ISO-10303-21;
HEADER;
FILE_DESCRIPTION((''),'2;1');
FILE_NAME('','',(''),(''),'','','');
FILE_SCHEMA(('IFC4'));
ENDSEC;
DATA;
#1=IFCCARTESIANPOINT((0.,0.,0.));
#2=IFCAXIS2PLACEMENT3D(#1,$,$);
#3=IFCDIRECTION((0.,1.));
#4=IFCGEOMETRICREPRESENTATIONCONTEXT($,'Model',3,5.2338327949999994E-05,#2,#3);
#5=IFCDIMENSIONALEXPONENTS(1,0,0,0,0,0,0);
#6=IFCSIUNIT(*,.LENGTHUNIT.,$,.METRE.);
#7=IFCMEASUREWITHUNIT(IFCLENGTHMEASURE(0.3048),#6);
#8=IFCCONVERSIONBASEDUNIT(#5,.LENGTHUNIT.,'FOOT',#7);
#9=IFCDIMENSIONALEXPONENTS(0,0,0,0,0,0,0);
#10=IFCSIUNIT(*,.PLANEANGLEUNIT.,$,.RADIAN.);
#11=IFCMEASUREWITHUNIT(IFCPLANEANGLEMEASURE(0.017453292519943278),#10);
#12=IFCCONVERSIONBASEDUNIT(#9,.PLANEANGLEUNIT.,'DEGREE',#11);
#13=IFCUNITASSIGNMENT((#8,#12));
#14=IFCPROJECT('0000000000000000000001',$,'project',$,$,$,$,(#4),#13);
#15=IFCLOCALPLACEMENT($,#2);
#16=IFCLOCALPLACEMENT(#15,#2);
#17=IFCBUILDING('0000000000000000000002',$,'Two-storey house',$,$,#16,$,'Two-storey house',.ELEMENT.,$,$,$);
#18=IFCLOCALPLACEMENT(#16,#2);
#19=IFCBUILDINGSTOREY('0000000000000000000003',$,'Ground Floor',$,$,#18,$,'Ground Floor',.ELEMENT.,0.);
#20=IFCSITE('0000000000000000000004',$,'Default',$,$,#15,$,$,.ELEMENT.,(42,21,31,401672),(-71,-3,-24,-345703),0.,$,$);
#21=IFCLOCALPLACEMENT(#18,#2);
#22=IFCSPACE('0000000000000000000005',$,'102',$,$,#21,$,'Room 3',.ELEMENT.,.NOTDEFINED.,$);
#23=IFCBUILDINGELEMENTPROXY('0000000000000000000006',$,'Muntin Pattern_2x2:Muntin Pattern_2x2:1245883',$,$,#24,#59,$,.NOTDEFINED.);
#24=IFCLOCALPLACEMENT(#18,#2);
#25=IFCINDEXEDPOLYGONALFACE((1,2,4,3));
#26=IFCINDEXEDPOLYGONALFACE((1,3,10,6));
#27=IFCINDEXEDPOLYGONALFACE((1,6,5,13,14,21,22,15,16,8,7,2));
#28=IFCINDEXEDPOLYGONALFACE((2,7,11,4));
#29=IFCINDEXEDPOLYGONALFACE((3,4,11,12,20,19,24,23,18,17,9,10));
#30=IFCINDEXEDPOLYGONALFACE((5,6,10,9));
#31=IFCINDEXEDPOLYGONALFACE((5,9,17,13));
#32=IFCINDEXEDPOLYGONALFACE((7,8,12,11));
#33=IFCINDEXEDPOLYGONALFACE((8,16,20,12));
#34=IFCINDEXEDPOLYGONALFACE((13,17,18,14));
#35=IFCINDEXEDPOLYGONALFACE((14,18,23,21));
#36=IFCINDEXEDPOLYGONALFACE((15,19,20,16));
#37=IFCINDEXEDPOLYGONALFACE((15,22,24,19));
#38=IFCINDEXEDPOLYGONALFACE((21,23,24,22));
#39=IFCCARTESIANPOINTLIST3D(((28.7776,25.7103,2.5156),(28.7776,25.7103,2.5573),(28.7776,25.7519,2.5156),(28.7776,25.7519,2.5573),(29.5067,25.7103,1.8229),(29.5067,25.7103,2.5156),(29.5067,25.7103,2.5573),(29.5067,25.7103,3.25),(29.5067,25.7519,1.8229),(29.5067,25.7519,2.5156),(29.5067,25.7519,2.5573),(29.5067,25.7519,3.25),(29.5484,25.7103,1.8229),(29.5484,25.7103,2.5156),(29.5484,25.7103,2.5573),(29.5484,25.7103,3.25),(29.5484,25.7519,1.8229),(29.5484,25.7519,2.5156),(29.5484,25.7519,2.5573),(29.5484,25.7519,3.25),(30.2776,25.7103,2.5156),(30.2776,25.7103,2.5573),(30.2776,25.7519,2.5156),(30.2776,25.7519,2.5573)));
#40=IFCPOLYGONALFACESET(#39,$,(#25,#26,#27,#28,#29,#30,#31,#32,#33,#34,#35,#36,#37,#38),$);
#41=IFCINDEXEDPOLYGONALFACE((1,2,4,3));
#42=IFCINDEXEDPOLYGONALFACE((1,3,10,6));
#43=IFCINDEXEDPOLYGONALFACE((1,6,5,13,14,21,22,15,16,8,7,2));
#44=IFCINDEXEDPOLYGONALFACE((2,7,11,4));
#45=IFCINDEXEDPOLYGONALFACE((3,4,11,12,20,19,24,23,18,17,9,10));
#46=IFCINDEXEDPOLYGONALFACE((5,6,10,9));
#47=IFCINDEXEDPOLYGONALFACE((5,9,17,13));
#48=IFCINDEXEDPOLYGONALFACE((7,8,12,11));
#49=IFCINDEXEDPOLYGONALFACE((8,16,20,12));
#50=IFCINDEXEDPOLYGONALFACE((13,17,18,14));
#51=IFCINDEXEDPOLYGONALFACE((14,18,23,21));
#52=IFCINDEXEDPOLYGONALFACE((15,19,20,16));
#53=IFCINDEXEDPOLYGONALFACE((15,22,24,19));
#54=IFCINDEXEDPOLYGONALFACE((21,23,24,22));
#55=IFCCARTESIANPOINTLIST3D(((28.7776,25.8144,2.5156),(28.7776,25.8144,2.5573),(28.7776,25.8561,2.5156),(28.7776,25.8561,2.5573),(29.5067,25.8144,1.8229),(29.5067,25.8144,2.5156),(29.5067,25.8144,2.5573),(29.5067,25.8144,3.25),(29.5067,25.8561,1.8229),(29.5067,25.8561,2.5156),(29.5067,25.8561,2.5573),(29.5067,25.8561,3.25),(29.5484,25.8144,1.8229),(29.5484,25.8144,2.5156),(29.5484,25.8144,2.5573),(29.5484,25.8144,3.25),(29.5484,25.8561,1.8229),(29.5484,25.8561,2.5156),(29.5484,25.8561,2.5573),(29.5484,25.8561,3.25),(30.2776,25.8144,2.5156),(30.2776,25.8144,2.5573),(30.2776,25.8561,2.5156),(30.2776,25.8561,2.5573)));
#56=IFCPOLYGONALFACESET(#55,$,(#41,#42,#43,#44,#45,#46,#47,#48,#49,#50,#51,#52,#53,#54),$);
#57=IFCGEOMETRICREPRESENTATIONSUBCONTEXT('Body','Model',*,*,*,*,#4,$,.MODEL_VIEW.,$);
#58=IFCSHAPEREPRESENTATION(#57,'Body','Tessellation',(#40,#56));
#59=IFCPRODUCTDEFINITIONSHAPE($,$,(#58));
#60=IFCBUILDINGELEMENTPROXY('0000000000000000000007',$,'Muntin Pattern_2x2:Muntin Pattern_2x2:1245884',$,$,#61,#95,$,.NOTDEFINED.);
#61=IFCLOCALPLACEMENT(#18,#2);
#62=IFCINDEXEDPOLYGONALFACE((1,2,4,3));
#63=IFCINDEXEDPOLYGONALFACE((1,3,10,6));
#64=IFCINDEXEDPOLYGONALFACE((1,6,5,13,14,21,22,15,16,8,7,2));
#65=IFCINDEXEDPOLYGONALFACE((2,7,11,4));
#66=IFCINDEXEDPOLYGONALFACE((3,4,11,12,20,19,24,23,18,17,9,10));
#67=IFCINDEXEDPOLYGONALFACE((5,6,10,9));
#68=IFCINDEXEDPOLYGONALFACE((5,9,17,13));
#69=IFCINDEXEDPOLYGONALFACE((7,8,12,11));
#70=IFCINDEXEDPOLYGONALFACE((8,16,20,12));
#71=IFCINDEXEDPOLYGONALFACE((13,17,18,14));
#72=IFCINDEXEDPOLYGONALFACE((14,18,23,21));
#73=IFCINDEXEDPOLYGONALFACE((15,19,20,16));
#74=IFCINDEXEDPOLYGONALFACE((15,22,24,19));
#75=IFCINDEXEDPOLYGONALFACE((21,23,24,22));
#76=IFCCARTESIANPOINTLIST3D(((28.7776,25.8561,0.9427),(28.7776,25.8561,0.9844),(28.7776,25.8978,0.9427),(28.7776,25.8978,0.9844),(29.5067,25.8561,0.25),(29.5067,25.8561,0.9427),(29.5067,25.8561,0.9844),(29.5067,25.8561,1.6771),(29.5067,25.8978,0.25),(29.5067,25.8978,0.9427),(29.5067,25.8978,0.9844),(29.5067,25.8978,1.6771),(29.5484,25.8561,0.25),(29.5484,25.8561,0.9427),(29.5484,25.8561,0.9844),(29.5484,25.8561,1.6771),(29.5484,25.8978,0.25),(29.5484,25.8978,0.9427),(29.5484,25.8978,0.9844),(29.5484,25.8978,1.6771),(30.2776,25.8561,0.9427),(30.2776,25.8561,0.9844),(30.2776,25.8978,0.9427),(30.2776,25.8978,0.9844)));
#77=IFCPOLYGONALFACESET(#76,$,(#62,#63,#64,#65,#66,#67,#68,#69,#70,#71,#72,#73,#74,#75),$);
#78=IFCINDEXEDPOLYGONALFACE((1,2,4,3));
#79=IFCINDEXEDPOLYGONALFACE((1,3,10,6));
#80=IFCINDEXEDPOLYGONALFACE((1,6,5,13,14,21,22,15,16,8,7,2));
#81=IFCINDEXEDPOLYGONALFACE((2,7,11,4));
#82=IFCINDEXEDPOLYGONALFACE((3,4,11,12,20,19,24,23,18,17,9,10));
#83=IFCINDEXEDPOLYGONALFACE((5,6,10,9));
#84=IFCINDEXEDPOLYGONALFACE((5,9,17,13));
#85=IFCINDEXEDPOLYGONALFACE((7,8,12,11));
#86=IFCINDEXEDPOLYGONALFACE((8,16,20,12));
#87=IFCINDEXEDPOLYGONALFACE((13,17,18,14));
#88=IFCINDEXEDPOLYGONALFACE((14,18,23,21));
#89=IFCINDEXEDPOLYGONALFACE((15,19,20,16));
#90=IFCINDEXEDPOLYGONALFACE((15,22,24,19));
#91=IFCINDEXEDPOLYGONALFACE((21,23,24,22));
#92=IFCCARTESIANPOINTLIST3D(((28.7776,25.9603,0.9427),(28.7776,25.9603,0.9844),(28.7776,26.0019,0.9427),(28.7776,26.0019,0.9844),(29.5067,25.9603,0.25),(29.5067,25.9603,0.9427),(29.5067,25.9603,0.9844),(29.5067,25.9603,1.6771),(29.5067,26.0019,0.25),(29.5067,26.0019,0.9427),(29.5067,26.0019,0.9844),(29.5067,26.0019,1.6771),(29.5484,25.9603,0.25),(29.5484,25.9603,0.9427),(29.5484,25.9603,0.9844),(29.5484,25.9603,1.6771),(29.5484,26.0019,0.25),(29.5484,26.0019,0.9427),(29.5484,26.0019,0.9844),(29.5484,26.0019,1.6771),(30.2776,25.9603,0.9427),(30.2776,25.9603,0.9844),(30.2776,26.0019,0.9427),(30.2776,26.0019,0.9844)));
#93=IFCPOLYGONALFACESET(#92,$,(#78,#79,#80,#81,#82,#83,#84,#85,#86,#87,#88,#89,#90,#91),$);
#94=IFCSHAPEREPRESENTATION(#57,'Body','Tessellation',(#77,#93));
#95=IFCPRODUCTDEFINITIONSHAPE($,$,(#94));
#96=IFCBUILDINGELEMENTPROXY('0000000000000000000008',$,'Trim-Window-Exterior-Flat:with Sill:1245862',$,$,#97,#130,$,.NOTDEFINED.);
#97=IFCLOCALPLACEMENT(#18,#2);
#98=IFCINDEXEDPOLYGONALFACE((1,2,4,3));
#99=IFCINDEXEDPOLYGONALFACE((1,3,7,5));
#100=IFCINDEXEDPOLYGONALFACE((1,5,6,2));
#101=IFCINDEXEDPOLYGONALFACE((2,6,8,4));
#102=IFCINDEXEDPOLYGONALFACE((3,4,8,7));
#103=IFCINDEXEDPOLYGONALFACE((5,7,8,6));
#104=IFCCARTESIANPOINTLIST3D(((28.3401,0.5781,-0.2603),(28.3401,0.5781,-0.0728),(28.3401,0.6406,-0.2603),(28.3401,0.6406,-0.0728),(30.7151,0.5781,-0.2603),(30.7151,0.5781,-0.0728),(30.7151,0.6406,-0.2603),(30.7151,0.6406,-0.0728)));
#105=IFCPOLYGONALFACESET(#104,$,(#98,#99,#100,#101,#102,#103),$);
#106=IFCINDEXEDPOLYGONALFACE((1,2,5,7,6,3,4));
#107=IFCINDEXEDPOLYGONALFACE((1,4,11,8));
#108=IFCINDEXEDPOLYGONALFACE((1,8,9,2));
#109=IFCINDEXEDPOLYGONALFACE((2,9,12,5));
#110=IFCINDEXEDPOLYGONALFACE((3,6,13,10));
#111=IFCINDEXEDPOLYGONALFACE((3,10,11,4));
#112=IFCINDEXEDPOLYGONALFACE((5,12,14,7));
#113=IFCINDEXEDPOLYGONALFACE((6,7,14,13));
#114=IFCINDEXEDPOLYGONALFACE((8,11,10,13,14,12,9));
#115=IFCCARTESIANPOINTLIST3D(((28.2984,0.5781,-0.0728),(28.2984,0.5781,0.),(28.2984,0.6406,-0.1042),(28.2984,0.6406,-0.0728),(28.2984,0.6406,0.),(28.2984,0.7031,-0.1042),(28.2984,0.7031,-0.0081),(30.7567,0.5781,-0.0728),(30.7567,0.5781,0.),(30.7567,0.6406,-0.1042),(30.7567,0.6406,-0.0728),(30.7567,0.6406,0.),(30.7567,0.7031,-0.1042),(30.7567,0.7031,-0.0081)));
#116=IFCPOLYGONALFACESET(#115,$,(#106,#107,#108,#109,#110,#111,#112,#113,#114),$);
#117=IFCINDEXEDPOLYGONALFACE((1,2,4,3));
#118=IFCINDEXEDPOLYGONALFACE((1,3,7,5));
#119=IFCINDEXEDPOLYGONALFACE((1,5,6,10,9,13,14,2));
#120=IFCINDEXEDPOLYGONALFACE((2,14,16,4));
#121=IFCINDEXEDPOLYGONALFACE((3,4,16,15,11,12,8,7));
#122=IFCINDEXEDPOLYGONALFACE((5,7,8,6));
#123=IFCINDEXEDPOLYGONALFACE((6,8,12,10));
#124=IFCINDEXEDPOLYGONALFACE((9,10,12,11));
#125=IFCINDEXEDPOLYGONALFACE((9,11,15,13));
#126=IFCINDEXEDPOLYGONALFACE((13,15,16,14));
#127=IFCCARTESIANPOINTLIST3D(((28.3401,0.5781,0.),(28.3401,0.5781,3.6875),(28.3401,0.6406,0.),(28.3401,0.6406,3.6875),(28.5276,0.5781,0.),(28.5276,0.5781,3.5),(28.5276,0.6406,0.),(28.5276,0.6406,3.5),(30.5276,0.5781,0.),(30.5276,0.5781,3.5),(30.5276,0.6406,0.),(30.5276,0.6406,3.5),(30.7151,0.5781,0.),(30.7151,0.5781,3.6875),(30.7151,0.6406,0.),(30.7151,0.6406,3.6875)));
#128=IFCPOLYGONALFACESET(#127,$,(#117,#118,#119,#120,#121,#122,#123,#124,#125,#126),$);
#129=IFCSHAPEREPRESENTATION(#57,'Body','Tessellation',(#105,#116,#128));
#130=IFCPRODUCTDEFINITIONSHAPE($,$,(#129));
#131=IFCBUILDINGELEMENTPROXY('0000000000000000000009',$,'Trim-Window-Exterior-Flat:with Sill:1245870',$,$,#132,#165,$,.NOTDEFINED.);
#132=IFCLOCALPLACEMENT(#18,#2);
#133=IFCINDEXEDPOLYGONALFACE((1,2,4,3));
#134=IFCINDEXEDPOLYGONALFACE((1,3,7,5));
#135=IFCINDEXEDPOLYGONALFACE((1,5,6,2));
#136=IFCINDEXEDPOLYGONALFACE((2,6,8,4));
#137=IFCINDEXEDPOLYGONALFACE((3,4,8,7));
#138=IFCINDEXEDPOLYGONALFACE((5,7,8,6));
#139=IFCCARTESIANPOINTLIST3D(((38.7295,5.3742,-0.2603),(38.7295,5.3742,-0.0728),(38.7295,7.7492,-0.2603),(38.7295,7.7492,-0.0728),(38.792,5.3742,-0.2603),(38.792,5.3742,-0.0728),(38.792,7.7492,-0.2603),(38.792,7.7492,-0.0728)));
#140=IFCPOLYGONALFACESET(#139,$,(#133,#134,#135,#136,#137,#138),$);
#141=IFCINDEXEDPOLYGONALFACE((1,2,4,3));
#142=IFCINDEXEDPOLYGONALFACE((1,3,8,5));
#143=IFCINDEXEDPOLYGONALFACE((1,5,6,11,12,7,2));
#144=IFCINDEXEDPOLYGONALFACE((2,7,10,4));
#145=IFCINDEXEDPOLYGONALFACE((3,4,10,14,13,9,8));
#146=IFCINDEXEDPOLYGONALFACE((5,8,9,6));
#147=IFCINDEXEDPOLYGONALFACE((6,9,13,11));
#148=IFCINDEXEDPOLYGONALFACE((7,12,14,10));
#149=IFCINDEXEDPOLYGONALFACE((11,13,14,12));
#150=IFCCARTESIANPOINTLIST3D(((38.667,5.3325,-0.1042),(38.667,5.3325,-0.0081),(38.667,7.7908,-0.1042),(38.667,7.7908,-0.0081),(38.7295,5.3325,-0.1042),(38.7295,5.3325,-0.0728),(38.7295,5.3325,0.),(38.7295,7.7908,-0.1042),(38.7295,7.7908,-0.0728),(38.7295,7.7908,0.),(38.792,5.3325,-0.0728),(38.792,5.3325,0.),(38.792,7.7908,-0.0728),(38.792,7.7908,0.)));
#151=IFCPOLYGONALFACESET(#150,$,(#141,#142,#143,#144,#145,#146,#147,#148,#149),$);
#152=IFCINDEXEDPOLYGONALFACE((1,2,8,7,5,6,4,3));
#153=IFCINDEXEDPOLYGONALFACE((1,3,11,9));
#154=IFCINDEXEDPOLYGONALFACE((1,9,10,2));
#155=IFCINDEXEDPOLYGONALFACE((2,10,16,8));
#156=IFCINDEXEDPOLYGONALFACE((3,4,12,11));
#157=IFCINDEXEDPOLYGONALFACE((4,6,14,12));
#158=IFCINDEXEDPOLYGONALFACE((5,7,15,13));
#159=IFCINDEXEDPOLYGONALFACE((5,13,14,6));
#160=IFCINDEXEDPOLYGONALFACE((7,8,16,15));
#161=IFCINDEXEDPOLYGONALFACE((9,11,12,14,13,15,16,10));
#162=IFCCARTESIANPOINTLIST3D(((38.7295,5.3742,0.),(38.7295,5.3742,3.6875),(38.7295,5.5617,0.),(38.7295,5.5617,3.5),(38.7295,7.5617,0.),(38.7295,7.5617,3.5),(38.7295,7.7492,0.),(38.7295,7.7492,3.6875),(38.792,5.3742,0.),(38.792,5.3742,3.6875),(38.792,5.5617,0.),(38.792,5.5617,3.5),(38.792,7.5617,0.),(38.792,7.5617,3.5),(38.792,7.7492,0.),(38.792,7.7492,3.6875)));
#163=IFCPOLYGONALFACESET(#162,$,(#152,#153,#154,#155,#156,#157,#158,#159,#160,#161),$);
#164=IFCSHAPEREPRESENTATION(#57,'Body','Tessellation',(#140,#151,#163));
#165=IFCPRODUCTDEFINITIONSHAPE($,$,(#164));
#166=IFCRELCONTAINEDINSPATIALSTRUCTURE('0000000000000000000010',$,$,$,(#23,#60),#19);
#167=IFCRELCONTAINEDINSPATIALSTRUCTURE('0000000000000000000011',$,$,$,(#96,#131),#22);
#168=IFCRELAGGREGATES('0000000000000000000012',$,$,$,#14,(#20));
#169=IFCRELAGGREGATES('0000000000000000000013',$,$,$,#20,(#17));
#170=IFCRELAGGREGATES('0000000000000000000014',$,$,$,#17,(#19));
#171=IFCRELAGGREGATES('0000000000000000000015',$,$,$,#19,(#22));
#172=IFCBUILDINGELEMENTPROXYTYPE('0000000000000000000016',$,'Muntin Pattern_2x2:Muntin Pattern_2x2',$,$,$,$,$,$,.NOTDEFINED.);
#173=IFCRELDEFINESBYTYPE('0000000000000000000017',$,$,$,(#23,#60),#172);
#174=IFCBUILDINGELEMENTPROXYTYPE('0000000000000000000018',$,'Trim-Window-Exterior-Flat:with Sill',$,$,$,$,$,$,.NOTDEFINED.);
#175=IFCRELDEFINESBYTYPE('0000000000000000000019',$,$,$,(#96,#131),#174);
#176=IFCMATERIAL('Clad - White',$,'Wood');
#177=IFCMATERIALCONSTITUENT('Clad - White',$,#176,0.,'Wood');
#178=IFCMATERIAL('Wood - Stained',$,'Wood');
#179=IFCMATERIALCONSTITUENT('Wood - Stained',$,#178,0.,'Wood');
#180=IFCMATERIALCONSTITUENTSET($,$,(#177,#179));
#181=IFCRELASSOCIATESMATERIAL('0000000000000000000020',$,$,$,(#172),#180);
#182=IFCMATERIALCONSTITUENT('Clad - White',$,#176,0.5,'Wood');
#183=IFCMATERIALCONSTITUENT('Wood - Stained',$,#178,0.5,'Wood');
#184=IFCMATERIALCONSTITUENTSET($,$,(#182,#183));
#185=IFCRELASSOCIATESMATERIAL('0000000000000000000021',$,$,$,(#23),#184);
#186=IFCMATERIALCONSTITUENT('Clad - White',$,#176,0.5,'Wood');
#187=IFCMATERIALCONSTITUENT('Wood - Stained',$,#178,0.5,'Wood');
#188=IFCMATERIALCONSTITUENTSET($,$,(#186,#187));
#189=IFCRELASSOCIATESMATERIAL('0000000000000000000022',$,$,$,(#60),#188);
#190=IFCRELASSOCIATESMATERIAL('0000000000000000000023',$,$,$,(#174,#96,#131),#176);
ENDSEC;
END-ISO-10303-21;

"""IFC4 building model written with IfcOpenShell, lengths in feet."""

from ifc_helpers import new_model, entity, si_unit, converted_unit, direction, frame, origin, place, context, subcontext, project, spatial, indexed_curve, outline, extrude, source, transform, mapped, material, constituent, constituent_set, type_object, type_shapes, element, save


model = new_model("IFC4")

# Units and contexts
model_context = context("Model", 3, precision=5.2338327949999994e-05, world=origin(), true_north=direction((0.0, 1.0)))
body_context = subcontext(model_context, "Body", "Model", "MODEL_VIEW")
ifc_project = project(units=[converted_unit("LENGTHUNIT", "FOOT", entity("IfcLengthMeasure", 0.3048), si_unit("LENGTHUNIT", "METRE"), dimensions=[1, 0, 0, 0, 0, 0, 0]), converted_unit("PLANEANGLEUNIT", "DEGREE", entity("IfcPlaneAngleMeasure", 0.017453292519943278), si_unit("PLANEANGLEUNIT", "RADIAN"), dimensions=[0, 0, 0, 0, 0, 0, 0])], contexts=[model_context])

# Site, building, storey
site_placement = place(None, origin())
site = spatial("IfcSite", under=ifc_project, at=site_placement, Name="Default", CompositionType="ELEMENT", RefLatitude=(42, 21, 31, 401672), RefLongitude=(-71, -3, -24, -345703), RefElevation=0.0)
building_placement = place(site_placement, origin())
building = spatial("IfcBuilding", under=site, at=building_placement, Name="Two-storey house", LongName="Two-storey house", CompositionType="ELEMENT")
storey_placement = place(building_placement, origin())
storey = spatial("IfcBuildingStorey", under=building, at=storey_placement, Name="Ground Floor", LongName="Ground Floor", CompositionType="ELEMENT", Elevation=0.0)

# Shared definitions
ifc_material_1 = material(Name="Wood - Stained", Category="Wood")

# Building element proxies
ifc_material_2 = material(Name="Clad - White", Category="Wood")
ifc_constituent_1 = constituent(ifc_material_2, Name="Clad - White", Category="Wood", fraction=0.0)
ifc_constituent_2 = constituent(ifc_material_1, Name="Wood - Stained", Category="Wood", fraction=0.0)
ifc_constituent_set_1 = constituent_set(constituents=[ifc_constituent_1, ifc_constituent_2])
building_element_proxy_type_1 = type_object("IfcBuildingElementProxyType", Name="Muntin Pattern_2x2:Muntin Pattern_2x2", PredefinedType="NOTDEFINED", material=ifc_constituent_set_1)
shared_shape_1 = source(origin(), body_context, "Body", "SweptSolid", [
    extrude(outline(indexed_curve([(0.0208, -0.0208), (0.7135, -0.0208), (0.7135, 0.0208), (0.0208, 0.0208), (0.0208, 0.75), (-0.0208, 0.75), (-0.0208, 0.0208), (-0.7135, 0.0208), (-0.7135, -0.0208), (-0.0208, -0.0208), (-0.0208, -0.75), (0.0208, -0.75), (0.0208, -0.0208)], self_intersect=False)), frame((0.0, 0.0312, 0.7135), z_axis=(0.0, 1.0, 0.0), x_axis=(0.0, 0.0, 1.0)), (0.0, 0.0, 1.0), 0.0417),
    extrude(outline(indexed_curve([(0.0208, -0.0208), (0.7135, -0.0208), (0.7135, 0.0208), (0.0208, 0.0208), (0.0208, 0.75), (-0.0208, 0.75), (-0.0208, 0.0208), (-0.7135, 0.0208), (-0.7135, -0.0208), (-0.0208, -0.0208), (-0.0208, -0.75), (0.0208, -0.75), (0.0208, -0.0208)], self_intersect=False)), frame((0.0, -0.0729, 0.7135), z_axis=(0.0, 1.0, 0.0), x_axis=(0.0, 0.0, 1.0)), (0.0, 0.0, 1.0), 0.0417),
])
type_shapes(building_element_proxy_type_1, [shared_shape_1])
ifc_constituent_3 = constituent(ifc_material_2, Name="Clad - White", Category="Wood", fraction=0.5)
ifc_constituent_4 = constituent(ifc_material_1, Name="Wood - Stained", Category="Wood", fraction=0.5)
ifc_constituent_set_2 = constituent_set(constituents=[ifc_constituent_3, ifc_constituent_4])
proxy_1_placement = place(storey_placement, frame((29.5276, 25.7832, 1.8229), z_axis=(0.0, 0.0, 1.0), x_axis=(-1.0, 0.0, 0.0)))
element("IfcBuildingElementProxy", 1, at=proxy_1_placement, inside=storey, type_object=building_element_proxy_type_1, material=ifc_constituent_set_2, Name="Muntin Pattern_2x2:Muntin Pattern_2x2:1245883", PredefinedType="NOTDEFINED", context=body_context, shape_type="MappedRepresentation", body=[
    mapped(shared_shape_1, transform((0.0, 0.0, 0.0), scale=1.0)),
])
ifc_constituent_5 = constituent(ifc_material_2, Name="Clad - White", Category="Wood", fraction=0.5)
ifc_constituent_6 = constituent(ifc_material_1, Name="Wood - Stained", Category="Wood", fraction=0.5)
ifc_constituent_set_3 = constituent_set(constituents=[ifc_constituent_5, ifc_constituent_6])
proxy_2_placement = place(storey_placement, frame((29.5276, 25.929, 0.25), z_axis=(0.0, 0.0, 1.0), x_axis=(-1.0, 0.0, 0.0)))
element("IfcBuildingElementProxy", 2, at=proxy_2_placement, inside=storey, type_object=building_element_proxy_type_1, material=ifc_constituent_set_3, Name="Muntin Pattern_2x2:Muntin Pattern_2x2:1245884", PredefinedType="NOTDEFINED", context=body_context, shape_type="MappedRepresentation", body=[
    mapped(shared_shape_1, transform((0.0, 0.0, 0.0), scale=1.0)),
])

# Shared definitions
space_1_placement = place(storey_placement, origin())
space_1 = spatial("IfcSpace", under=storey, at=space_1_placement, Name="102", LongName="Room 3", CompositionType="ELEMENT", PredefinedType="NOTDEFINED")

# Building element proxies
building_element_proxy_type_2 = type_object("IfcBuildingElementProxyType", Name="Trim-Window-Exterior-Flat:with Sill", PredefinedType="NOTDEFINED", material=ifc_material_2)
shared_shape_2 = source(origin(), body_context, "Body", "SweptSolid", [
    extrude(outline(indexed_curve([(-1.1875, -0.0938), (1.1875, -0.0938), (1.1875, 0.0938), (-1.1875, 0.0938), (-1.1875, -0.0938)], self_intersect=False)), frame((0.0, -3.6665, 0.0), z_axis=(0.0, 0.0, 1.0), x_axis=(-1.0, 0.0, 0.0)), (0.0, 0.0, 1.0), 0.0625),
    extrude(outline(indexed_curve([(-0.0625, -0.0525), (0.0, -0.0525), (0.0, -0.0211), (0.0625, -0.0211), (0.0625, 0.0517), (0.0, 0.0517), (-0.0625, 0.0436), (-0.0625, -0.0525)], self_intersect=False)), frame((-1.2292, -3.5517, 0.0625), z_axis=(1.0, 0.0, 0.0), x_axis=(0.0, 0.0, -1.0)), (0.0, 0.0, 1.0), 2.4583),
    extrude(outline(indexed_curve([(-1.8906, -1.1875), (1.7969, -1.1875), (1.7969, -1.0), (-1.7031, -1.0), (-1.7031, 1.0), (1.7969, 1.0), (1.7969, 1.1875), (-1.8906, 1.1875), (-1.8906, -1.1875)], self_intersect=False)), frame((0.0, -1.7031, 0.0), z_axis=(0.0, 0.0, 1.0), x_axis=(0.0, -1.0, 0.0)), (0.0, 0.0, 1.0), 0.0625),
])
type_shapes(building_element_proxy_type_2, [shared_shape_2])
for number, where, z_axis, x_axis, name in (
    (3, (29.5276, 0.5781, 3.5), (0.0, 1.0, 0.0), (-1.0, 0.0, 0.0), "Trim-Window-Exterior-Flat:with Sill:1245862"),
    (4, (38.792, 6.5617, 3.5), (-1.0, 0.0, 0.0), (0.0, -1.0, 0.0), "Trim-Window-Exterior-Flat:with Sill:1245870"),
):
    element("IfcBuildingElementProxy", number, at=place(space_1_placement, frame(where, z_axis=z_axis, x_axis=x_axis)), inside=space_1, type_object=building_element_proxy_type_2, material=ifc_material_2, Name=name, PredefinedType="NOTDEFINED", context=body_context, shape_type="MappedRepresentation", body=[
        mapped(shared_shape_2, transform((0.0, 0.0, 0.0), scale=1.0)),
    ])

save(model, "model.ifc")
